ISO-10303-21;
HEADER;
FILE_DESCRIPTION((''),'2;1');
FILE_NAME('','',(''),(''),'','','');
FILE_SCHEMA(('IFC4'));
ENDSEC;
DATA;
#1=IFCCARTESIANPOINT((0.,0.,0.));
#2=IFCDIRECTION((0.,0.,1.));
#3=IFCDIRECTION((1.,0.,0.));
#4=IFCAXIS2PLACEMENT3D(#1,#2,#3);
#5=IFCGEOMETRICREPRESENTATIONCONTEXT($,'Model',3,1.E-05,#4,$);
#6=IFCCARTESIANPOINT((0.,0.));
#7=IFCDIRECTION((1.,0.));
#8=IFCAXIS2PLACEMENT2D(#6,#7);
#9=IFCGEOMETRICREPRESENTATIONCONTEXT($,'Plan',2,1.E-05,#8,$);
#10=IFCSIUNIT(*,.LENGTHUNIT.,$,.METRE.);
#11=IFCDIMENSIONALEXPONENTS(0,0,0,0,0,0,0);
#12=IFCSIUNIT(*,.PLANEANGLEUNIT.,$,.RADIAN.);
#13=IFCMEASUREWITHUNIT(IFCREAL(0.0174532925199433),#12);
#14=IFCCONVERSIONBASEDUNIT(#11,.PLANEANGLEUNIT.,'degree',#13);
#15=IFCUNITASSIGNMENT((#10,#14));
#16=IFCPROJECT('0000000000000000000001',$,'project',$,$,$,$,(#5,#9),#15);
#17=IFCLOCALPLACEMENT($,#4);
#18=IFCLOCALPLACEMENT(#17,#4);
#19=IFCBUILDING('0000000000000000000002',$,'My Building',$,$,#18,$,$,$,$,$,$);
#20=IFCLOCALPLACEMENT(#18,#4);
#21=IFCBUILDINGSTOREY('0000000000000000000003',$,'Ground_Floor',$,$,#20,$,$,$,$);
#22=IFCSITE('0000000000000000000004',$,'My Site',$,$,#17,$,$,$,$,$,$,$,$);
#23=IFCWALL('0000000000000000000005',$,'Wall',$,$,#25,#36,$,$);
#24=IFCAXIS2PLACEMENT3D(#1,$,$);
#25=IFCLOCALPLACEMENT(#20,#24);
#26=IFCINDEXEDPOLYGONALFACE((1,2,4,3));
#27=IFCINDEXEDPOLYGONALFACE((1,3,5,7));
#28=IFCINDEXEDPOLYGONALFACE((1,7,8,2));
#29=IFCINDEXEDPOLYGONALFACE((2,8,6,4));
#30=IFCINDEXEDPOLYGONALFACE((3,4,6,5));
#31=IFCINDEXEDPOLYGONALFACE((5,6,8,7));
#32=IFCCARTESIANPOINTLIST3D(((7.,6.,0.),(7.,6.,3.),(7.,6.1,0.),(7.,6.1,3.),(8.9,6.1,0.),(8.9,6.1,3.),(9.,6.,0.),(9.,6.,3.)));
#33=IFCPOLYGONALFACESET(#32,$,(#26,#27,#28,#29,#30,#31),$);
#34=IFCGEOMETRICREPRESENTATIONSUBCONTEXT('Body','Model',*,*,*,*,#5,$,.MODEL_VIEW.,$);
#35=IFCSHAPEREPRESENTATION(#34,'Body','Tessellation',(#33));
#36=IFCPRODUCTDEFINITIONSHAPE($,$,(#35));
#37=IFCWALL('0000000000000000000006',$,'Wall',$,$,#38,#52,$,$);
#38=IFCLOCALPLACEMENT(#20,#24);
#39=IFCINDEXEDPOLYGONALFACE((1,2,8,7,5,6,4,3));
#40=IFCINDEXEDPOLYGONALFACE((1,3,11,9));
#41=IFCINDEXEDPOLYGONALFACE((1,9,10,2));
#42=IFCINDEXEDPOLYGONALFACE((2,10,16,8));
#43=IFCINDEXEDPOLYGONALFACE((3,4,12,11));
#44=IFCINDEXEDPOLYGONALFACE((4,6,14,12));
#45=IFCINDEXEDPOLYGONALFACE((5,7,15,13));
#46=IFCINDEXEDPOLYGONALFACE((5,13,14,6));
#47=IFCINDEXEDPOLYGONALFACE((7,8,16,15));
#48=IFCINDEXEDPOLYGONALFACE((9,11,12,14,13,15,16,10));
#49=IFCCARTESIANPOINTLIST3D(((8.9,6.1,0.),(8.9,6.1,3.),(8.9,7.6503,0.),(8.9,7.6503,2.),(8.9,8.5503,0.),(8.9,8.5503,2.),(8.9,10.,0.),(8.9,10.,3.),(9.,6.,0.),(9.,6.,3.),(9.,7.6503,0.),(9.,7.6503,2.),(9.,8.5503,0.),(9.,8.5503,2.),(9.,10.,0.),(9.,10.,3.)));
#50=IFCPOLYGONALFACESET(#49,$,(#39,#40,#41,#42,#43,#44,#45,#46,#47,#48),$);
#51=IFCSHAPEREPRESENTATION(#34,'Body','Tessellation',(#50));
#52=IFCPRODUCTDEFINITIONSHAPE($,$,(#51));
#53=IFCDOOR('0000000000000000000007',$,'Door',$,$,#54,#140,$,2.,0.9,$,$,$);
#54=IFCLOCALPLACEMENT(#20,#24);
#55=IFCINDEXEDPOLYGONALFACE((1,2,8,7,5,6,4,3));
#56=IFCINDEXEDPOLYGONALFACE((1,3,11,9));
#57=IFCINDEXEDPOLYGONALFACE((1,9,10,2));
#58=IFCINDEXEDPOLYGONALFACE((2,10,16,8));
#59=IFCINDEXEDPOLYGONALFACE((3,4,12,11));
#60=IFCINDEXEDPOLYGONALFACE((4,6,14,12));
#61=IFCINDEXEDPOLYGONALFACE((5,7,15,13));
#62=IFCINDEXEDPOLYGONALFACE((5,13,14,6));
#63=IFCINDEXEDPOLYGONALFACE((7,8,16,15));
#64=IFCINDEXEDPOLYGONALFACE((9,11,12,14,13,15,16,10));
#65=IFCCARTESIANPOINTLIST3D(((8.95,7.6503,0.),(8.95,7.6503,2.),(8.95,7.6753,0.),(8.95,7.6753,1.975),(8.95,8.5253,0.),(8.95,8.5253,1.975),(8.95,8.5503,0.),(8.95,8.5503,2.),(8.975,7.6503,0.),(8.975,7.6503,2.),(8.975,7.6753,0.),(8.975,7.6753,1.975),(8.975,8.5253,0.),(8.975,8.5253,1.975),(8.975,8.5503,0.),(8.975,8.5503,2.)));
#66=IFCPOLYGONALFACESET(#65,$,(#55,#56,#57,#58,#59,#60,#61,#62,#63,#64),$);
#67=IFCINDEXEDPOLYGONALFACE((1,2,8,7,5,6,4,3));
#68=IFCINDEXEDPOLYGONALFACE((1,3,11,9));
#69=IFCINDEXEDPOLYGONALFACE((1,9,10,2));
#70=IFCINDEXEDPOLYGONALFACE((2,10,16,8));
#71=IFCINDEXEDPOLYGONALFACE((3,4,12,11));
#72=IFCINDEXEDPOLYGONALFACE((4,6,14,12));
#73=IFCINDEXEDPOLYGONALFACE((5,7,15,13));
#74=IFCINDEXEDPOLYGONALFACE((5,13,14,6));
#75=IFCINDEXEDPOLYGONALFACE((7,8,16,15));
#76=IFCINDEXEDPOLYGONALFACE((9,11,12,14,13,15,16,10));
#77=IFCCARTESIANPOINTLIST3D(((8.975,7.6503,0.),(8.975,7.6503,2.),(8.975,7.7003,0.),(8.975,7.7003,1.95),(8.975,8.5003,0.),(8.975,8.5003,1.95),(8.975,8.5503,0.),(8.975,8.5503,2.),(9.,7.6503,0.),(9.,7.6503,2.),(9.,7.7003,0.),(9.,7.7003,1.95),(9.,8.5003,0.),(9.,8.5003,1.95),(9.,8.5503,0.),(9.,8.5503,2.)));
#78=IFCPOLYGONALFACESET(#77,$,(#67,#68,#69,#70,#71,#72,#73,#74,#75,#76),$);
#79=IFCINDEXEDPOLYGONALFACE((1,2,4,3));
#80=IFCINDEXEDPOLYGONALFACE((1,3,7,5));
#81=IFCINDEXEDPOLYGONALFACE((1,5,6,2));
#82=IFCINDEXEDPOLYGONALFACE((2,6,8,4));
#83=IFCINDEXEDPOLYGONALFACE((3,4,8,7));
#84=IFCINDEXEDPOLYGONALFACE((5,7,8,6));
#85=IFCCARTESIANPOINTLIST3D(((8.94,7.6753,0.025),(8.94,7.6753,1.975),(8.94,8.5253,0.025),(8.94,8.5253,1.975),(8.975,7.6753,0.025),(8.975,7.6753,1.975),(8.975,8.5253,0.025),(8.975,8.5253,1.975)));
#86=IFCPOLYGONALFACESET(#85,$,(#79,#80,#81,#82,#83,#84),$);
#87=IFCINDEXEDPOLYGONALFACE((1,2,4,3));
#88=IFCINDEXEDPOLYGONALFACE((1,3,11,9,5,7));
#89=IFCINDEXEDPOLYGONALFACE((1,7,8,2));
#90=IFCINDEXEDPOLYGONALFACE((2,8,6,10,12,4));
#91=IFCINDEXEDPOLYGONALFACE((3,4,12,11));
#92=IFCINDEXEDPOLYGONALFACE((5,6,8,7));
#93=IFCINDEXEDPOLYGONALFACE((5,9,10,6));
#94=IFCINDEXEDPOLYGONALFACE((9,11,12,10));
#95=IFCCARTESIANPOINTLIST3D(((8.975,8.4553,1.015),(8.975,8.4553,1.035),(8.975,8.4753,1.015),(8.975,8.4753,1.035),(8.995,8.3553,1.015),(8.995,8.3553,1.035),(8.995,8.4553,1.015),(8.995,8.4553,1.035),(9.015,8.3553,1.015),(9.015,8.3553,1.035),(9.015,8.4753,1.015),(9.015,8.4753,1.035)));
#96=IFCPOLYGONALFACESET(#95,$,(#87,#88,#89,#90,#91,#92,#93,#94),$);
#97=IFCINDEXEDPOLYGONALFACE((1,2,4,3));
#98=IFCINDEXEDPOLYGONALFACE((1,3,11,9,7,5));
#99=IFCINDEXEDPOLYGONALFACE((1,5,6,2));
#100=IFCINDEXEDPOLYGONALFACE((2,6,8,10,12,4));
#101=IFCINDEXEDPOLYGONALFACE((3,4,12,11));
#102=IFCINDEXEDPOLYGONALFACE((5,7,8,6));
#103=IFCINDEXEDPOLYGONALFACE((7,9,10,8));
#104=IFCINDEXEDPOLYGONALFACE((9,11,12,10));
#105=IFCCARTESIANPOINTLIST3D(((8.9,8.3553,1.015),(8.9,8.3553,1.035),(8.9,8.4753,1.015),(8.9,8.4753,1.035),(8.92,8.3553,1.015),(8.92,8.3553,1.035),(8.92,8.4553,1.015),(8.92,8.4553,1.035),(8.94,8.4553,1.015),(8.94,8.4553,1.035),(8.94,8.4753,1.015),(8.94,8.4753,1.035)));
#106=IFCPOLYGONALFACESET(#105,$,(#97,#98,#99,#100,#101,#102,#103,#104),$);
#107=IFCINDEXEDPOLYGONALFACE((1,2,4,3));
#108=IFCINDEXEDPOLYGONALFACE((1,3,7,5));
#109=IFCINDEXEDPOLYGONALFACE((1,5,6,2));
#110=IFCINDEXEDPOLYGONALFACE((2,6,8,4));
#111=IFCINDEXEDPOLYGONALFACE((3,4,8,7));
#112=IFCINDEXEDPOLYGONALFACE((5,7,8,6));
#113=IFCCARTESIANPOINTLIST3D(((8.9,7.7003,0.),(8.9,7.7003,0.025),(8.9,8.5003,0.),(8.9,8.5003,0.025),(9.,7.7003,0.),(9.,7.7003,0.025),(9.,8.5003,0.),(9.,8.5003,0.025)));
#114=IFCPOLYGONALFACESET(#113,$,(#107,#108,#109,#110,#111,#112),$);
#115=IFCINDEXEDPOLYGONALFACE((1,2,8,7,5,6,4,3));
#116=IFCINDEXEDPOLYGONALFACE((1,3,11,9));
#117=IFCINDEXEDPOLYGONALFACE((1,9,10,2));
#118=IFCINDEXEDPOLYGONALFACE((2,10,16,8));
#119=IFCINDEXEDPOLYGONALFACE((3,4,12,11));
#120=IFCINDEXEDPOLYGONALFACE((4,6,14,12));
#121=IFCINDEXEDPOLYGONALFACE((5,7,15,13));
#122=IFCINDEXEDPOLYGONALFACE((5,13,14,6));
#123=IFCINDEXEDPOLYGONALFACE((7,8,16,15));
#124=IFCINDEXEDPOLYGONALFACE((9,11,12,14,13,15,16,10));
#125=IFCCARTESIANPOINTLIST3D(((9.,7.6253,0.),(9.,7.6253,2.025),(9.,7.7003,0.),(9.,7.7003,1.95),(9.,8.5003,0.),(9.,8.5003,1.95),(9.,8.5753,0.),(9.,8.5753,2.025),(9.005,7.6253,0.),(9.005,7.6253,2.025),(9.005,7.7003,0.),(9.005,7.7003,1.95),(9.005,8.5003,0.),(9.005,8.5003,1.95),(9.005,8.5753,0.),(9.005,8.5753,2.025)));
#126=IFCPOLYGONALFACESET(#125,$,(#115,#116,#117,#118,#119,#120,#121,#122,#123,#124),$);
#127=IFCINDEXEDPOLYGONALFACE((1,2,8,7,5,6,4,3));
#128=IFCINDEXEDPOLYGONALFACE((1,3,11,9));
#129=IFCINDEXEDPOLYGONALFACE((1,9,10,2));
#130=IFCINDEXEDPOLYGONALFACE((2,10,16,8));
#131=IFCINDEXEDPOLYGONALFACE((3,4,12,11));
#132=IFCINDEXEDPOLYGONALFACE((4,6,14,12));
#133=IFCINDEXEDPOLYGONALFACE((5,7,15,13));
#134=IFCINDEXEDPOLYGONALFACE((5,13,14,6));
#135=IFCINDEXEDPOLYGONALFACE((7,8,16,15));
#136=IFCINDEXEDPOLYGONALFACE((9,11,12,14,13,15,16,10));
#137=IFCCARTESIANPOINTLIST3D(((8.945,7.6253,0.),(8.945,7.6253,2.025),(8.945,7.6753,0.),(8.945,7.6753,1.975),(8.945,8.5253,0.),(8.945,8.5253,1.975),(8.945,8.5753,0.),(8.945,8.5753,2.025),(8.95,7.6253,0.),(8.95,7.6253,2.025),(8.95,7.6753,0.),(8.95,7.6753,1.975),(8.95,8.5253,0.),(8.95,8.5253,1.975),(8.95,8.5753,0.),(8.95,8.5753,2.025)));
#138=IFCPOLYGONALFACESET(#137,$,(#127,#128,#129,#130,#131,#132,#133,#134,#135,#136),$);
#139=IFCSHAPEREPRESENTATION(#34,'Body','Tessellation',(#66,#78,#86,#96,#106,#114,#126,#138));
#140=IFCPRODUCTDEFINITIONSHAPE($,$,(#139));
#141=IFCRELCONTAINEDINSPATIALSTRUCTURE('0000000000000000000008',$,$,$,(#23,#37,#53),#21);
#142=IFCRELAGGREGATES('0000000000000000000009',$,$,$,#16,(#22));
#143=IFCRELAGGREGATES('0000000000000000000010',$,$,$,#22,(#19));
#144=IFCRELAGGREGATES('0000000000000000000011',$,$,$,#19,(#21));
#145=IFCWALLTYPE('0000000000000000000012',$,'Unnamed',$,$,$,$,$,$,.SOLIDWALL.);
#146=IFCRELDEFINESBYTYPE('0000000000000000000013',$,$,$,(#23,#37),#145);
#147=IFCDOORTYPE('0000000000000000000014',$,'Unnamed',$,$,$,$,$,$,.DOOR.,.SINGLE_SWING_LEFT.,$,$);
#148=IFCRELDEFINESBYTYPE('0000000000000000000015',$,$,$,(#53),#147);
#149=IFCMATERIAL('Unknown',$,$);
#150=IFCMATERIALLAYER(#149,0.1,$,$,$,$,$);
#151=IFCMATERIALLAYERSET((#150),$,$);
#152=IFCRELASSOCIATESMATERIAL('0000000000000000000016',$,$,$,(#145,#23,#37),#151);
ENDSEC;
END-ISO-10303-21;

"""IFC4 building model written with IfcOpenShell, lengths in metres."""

from ifc_helpers import new_model, entity, si_unit, converted_unit, frame, origin_with_axes, origin_2d_with_axis, place, context, subcontext, project, spatial, line, indexed_curve, outline, extrude, shape, source, transform, mapped, material, layer, layer_set, layer_usage, type_object, type_shapes, element, fill, save


model = new_model("IFC4")

# Units and contexts
model_context = context("Model", 3, precision=1e-05, world=origin_with_axes())
plan_context = context("Plan", 2, precision=1e-05, world=origin_2d_with_axis())
body_context_1 = subcontext(model_context, "Body", "Model", "MODEL_VIEW")
body_context_2 = subcontext(plan_context, "Body", "Plan", "PLAN_VIEW")
ifc_project = project(units=[si_unit("LENGTHUNIT", "METRE"), converted_unit("PLANEANGLEUNIT", "degree", entity("IfcReal", 0.0174532925199433), si_unit("PLANEANGLEUNIT", "RADIAN"), dimensions=[0, 0, 0, 0, 0, 0, 0])], contexts=[model_context, plan_context])

# Site, building, storey
site_placement = place(None, origin_with_axes())
site = spatial("IfcSite", under=ifc_project, at=site_placement, Name="My Site")
building_placement = place(site_placement, origin_with_axes())
building = spatial("IfcBuilding", under=site, at=building_placement, Name="My Building")
storey_placement = place(building_placement, origin_with_axes())
storey = spatial("IfcBuildingStorey", under=building, at=storey_placement, Name="Ground_Floor")

# Shared definitions
ifc_material = material(Name="Unknown")
ifc_layer = layer(ifc_material, 0.1)
ifc_layer_set = layer_set([ifc_layer])
wall_type = type_object("IfcWallType", Name="Unnamed", PredefinedType="SOLIDWALL", material=ifc_layer_set)

# Wall
ifc_layer_usage_1 = layer_usage(ifc_layer_set, "AXIS2", "POSITIVE", 0.0)
wall_1_placement = place(storey_placement, frame((7.0, 6.0, 0.0), z_axis=(0.0, 0.0, 1.0), x_axis=(1.0, 0.0, 0.0)))
element("IfcWall", 1, at=wall_1_placement, inside=storey, type_object=wall_type, material=ifc_layer_usage_1, Name="Wall", context=body_context_1, shape_type="SweptSolid", body=[
    extrude(outline(indexed_curve([(0.0, 0.0), (0.0, 0.1), (1.9, 0.1), (2.0, 0.0)], segments=[line(1, 2, 3, 4, 1)])), origin_with_axes(), (0.0, 0.0, 1.0), 3.0),
])

# Wall, opening, door
ifc_layer_usage_2 = layer_usage(ifc_layer_set, "AXIS2", "POSITIVE", 0.0)
wall_2_placement = place(storey_placement, frame((9.0, 6.0, 0.0), z_axis=(0.0, 0.0, 1.0), x_axis=(0.0, 1.0, 0.0)))
wall_2 = element("IfcWall", 2, at=wall_2_placement, inside=storey, type_object=wall_type, material=ifc_layer_usage_2, Name="Wall", context=body_context_1, shape_type="SweptSolid", body=[
    extrude(outline(indexed_curve([(0.0, 0.0), (0.1, 0.1), (4.0, 0.1), (4.0, 0.0)], segments=[line(1, 2, 3, 4, 1)])), origin_with_axes(), (0.0, 0.0, 1.0), 3.0),
])
shared_shape_1 = source(origin_with_axes(), body_context_1, "Body", "SweptSolid", [
    extrude(outline(indexed_curve([(0.0, 0.0), (0.9, 0.0), (0.9, 2.0), (0.0, 2.0)], segments=[line(1, 2, 3, 4, 1)])), frame((0.0, -0.6, 0.0), z_axis=(0.0, -1.0, 0.0), x_axis=(1.0, 0.0, 0.0)), (0.0, 0.0, -1.0), 1.2),
])
opening_1_placement = place(wall_2_placement, frame((1.6503, 0.0, 0.0), z_axis=(0.0, 0.0, 1.0), x_axis=(1.0, 0.0, 0.0)))
opening_1 = element("IfcOpeningElement", 3, at=opening_1_placement, cuts=wall_2, PredefinedType="OPENING", context=body_context_1, shape_type="MappedRepresentation", body=[
    mapped(shared_shape_1, transform((0.0, 0.0, 0.0), x_axis=(1.0, 0.0, 0.0), y_axis=(0.0, 1.0, 0.0), z_axis=(0.0, 0.0, 1.0), scale=1.0)),
])
door_type_1 = type_object("IfcDoorType", Name="Unnamed", OperationType="SINGLE_SWING_LEFT", PredefinedType="DOOR")
shared_shape_2 = source(origin_with_axes(), body_context_1, "Body", "SweptSolid", [
    extrude(outline(indexed_curve([(0.0, 0.0), (0.0, 2.0), (0.9, 2.0), (0.9, 0.0), (0.875, 0.0), (0.875, 1.975), (0.025, 1.975), (0.025, 0.0)], segments=[line(1, 2, 3, 4, 5, 6, 7, 8, 1)])), frame((0.0, 0.025, 0.0), z_axis=(0.0, -1.0, 0.0), x_axis=(1.0, 0.0, 0.0)), (0.0, 0.0, -1.0), 0.025),
    extrude(outline(indexed_curve([(0.0, 0.0), (0.0, 2.0), (0.9, 2.0), (0.9, 0.0), (0.85, 0.0), (0.85, 1.95), (0.05, 1.95), (0.05, 0.0)], segments=[line(1, 2, 3, 4, 5, 6, 7, 8, 1)])), frame((0.0, 0.0, 0.0), z_axis=(0.0, -1.0, 0.0), x_axis=(1.0, 0.0, 0.0)), (0.0, 0.0, -1.0), 0.025),
    extrude(outline(indexed_curve([(0.0, 0.0), (0.85, 0.0), (0.85, 0.035), (0.0, 0.035)], segments=[line(1, 2, 3, 4, 1)])), frame((0.025, 0.025, 0.025), z_axis=(0.0, 0.0, 1.0), x_axis=(1.0, 0.0, 0.0)), (0.0, 0.0, 1.0), 1.95),
    extrude(outline(indexed_curve([(0.0, 0.0), (0.0, -0.04), (-0.12, -0.04), (-0.12, -0.02), (-0.02, -0.02), (-0.02, 0.0)], segments=[line(1, 2, 3, 4, 5, 6, 1)])), frame((0.825, 0.025, 1.015), z_axis=(0.0, 0.0, 1.0), x_axis=(1.0, 0.0, 0.0)), (0.0, 0.0, 1.0), 0.02),
    extrude(outline(indexed_curve([(0.0, 0.0), (0.0, 0.04), (-0.12, 0.04), (-0.12, 0.02), (-0.02, 0.02), (-0.02, 0.0)], segments=[line(1, 2, 3, 4, 5, 6, 1)])), frame((0.825, 0.06, 1.015), z_axis=(0.0, 0.0, 1.0), x_axis=(1.0, 0.0, 0.0)), (0.0, 0.0, 1.0), 0.02),
    extrude(outline(indexed_curve([(0.0, 0.0), (0.8, 0.0), (0.8, 0.1), (0.0, 0.1)], segments=[line(1, 2, 3, 4, 1)])), frame((0.05, 0.0, 0.0), z_axis=(0.0, 0.0, 1.0), x_axis=(1.0, 0.0, 0.0)), (0.0, 0.0, 1.0), 0.025),
    extrude(outline(indexed_curve([(0.0, 0.0), (0.0, 2.025), (0.95, 2.025), (0.95, 0.0), (0.875, 0.0), (0.875, 1.95), (0.075, 1.95), (0.075, 0.0)], segments=[line(1, 2, 3, 4, 5, 6, 7, 8, 1)])), frame((-0.025, -0.005, 0.0), z_axis=(0.0, -1.0, 0.0), x_axis=(1.0, 0.0, 0.0)), (0.0, 0.0, -1.0), 0.005),
    extrude(outline(indexed_curve([(0.0, 0.0), (0.0, 2.025), (0.95, 2.025), (0.95, 0.0), (0.9, 0.0), (0.9, 1.975), (0.05, 1.975), (0.05, 0.0)], segments=[line(1, 2, 3, 4, 5, 6, 7, 8, 1)])), frame((-0.025, 0.05, 0.0), z_axis=(0.0, -1.0, 0.0), x_axis=(1.0, 0.0, 0.0)), (0.0, 0.0, -1.0), 0.005),
])
shared_shape_3 = source(origin_with_axes(), body_context_2, "Body", "Curve2D", [
    entity("IfcIndexedPolyCurve", entity("IfcCartesianPointList2D", [[0.0, 0.0], [0.0, 0.05], [0.025, 0.05], [0.025, 0.025], [0.05, 0.025], [0.05, 0.0]]), [entity("IfcLineIndex", [1, 2, 3, 4, 5, 6, 1])]),
    entity("IfcIndexedPolyCurve", entity("IfcCartesianPointList2D", [[0.9, 0.0], [0.9, 0.05], [0.875, 0.05], [0.875, 0.025], [0.85, 0.025], [0.85, 0.0]]), [entity("IfcLineIndex", [1, 2, 3, 4, 5, 6, 1])]),
    entity("IfcTrimmedCurve", entity("IfcEllipse", entity("IfcAxis2Placement2D", entity("IfcCartesianPoint", [0.06, 0.05]), entity("IfcDirection", [1.0, 0.0])), 0.815, 0.85), [entity("IfcCartesianPoint", [0.875, 0.05])], [entity("IfcCartesianPoint", [0.06, 0.9])], True, "CARTESIAN"),
    entity("IfcIndexedPolyCurve", entity("IfcCartesianPointList2D", [[0.025, 0.05], [0.06, 0.05], [0.06, 0.9], [0.025, 0.9]]), [entity("IfcLineIndex", [1, 2, 3, 4, 1])]),
])
type_shapes(door_type_1, [shared_shape_2, shared_shape_3])
door_1_placement = place(opening_1_placement, frame((0.0, 0.0, 0.0), z_axis=(0.0, 0.0, 1.0), x_axis=(1.0, 0.0, 0.0)))
door_1 = element("IfcDoor", 4, at=door_1_placement, inside=storey, type_object=door_type_1, Name="Door", OverallHeight=2.0, OverallWidth=0.9, shapes=[
    shape(body_context_1, "Body", "MappedRepresentation", [mapped(shared_shape_2, transform((0.0, 0.0, 0.0), x_axis=(1.0, 0.0, 0.0), y_axis=(0.0, 1.0, 0.0), z_axis=(0.0, 0.0, 1.0), scale=1.0))]),
    shape(body_context_2, "Body", "MappedRepresentation", [mapped(shared_shape_3, transform((0.0, 0.0, 0.0), x_axis=(1.0, 0.0, 0.0), y_axis=(0.0, 1.0, 0.0), z_axis=(0.0, 0.0, 1.0), scale=1.0))]),
])
fill(opening_1, door_1)

save(model, "model.ifc")
